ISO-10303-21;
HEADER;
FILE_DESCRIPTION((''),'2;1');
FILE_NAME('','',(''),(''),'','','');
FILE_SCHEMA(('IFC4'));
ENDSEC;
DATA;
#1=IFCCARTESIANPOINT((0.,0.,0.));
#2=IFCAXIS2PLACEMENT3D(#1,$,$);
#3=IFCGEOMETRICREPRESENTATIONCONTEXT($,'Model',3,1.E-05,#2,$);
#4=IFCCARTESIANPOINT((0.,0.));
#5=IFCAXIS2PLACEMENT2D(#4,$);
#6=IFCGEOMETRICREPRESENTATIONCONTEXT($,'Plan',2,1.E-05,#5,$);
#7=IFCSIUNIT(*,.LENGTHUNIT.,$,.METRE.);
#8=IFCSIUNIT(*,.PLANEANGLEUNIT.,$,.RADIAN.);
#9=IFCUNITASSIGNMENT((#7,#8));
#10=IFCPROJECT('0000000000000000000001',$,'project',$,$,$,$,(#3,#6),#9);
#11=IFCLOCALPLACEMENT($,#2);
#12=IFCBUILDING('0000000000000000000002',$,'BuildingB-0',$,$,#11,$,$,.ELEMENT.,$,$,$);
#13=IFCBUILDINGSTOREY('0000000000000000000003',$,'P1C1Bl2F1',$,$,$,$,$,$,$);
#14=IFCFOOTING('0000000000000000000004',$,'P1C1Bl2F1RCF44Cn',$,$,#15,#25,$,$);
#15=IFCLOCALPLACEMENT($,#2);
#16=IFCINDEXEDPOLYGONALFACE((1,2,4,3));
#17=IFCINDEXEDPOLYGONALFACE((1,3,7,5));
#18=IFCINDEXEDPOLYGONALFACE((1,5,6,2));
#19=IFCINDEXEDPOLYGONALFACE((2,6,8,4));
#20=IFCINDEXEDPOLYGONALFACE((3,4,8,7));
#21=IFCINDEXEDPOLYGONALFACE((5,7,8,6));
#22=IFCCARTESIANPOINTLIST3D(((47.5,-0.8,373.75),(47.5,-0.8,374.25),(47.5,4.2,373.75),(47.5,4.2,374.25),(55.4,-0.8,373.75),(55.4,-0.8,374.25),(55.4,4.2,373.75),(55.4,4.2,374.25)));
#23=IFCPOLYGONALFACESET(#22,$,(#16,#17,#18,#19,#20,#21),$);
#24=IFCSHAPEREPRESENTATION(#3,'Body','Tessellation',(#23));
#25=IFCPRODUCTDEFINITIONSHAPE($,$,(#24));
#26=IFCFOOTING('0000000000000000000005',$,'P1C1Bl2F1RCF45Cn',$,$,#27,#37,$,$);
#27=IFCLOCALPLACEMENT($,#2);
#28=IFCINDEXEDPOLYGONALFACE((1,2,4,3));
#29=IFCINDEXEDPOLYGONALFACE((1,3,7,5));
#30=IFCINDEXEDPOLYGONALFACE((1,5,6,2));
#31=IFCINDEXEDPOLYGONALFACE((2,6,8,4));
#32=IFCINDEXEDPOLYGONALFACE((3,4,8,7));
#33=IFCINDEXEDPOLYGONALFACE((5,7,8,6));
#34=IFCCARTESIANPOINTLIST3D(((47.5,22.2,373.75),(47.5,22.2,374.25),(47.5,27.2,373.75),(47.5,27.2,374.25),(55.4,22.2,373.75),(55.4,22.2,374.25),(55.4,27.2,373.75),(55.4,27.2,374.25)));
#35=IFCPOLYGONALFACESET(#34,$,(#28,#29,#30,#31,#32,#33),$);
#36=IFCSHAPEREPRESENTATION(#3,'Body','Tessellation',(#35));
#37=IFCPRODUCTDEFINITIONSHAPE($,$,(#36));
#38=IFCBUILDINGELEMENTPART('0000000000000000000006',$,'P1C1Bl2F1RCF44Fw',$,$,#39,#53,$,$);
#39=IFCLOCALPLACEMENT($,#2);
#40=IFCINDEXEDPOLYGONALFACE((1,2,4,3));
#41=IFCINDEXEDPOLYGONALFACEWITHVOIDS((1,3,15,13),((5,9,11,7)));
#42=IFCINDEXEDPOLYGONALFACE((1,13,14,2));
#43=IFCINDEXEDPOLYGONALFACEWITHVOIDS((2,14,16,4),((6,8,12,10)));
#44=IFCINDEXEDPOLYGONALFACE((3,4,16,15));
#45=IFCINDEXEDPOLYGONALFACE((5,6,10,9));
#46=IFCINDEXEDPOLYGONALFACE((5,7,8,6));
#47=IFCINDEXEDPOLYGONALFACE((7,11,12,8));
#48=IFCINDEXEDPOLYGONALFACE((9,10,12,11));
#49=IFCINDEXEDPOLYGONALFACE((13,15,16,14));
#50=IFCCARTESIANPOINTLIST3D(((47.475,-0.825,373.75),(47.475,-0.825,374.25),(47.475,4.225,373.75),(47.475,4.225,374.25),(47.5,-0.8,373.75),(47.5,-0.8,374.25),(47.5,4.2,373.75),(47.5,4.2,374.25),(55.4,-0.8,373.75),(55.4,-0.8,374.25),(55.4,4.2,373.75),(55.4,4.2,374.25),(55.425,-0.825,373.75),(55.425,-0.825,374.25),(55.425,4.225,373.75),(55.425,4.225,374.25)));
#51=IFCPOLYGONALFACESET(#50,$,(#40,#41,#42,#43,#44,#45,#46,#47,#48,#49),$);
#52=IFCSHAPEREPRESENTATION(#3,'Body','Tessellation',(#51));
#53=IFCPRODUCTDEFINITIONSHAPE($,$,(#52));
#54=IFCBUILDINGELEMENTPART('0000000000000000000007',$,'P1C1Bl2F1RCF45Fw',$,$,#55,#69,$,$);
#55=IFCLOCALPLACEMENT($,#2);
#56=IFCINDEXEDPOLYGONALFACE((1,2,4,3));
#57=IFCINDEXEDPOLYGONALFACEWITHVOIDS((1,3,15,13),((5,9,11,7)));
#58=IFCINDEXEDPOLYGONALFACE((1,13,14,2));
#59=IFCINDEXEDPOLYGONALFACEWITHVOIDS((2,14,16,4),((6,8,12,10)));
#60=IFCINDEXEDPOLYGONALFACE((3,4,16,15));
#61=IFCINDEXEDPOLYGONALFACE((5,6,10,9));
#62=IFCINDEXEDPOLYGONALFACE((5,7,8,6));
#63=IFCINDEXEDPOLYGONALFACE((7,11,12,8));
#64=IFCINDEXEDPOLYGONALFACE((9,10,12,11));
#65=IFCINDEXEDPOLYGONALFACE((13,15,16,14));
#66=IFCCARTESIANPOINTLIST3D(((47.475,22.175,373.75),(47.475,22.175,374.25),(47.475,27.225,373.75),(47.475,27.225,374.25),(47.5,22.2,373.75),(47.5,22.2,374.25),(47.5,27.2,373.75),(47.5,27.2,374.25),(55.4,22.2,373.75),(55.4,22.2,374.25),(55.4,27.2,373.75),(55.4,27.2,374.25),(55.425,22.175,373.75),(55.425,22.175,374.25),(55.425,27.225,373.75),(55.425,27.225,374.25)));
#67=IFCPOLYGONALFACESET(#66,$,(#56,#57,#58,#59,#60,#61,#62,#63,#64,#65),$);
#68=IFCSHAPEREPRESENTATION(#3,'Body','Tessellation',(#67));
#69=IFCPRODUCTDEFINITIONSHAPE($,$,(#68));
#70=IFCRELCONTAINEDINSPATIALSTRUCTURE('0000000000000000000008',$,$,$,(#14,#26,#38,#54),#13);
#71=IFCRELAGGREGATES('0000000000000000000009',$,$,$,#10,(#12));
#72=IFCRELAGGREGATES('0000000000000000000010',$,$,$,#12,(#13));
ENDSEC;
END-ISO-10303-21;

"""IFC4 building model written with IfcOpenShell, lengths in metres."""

from ifc_helpers import new_model, si_unit, origin, origin_2d, place, context, project, spatial, polyline, outline, extrude, element, save


model = new_model("IFC4")

# Units and contexts
model_context = context("Model", 3, precision=1e-05, world=origin())
plan_context = context("Plan", 2, precision=1e-05, world=origin_2d())
ifc_project = project(units=[si_unit("LENGTHUNIT", "METRE"), si_unit("PLANEANGLEUNIT", "RADIAN")], contexts=[model_context, plan_context])

# Building, storey
building_placement = place(None, origin())
building = spatial("IfcBuilding", under=ifc_project, at=building_placement, Name="BuildingB-0", CompositionType="ELEMENT")
storey = spatial("IfcBuildingStorey", under=building, Name="P1C1Bl2F1")

# Footings
element("IfcFooting", 1, inside=storey, Name="P1C1Bl2F1RCF44Cn", context=model_context, shape_type="SweptSolid", body=[
    extrude(outline(polyline([(55.4, 4.2, 373.75), (47.5, 4.2, 373.75), (47.5, -0.8, 373.75), (55.4, -0.8, 373.75), (55.4, 4.2, 373.75)])), None, (0.0, 0.0, 1.0), 0.5),
])
element("IfcFooting", 2, inside=storey, Name="P1C1Bl2F1RCF45Cn", context=model_context, shape_type="SweptSolid", body=[
    extrude(outline(polyline([(55.4, 27.2, 373.75), (47.5, 27.2, 373.75), (47.5, 22.2, 373.75), (55.4, 22.2, 373.75), (55.4, 27.2, 373.75)])), None, (0.0, 0.0, 1.0), 0.5),
])

# Building element part, opening
building_element_part_1 = element("IfcBuildingElementPart", 3, inside=storey, Name="P1C1Bl2F1RCF44Fw", context=model_context, shape_type="SweptSolid", body=[
    extrude(outline(polyline([(55.425, 4.225, 373.75), (47.475, 4.225, 373.75), (47.475, -0.825, 373.75), (55.425, -0.825, 373.75), (55.425, 4.225, 373.75)])), None, (0.0, 0.0, 1.0), 0.5),
])
element("IfcOpeningElement", 4, inside=storey, cuts=building_element_part_1, context=model_context, shape_type="SweptSolid", body=[
    extrude(outline(polyline([(55.4, 4.2, 373.75), (47.5, 4.2, 373.75), (47.5, -0.8, 373.75), (55.4, -0.8, 373.75), (55.4, 4.2, 373.75)])), None, (0.0, 0.0, 1.0), 0.5),
])

# Building element part, opening
building_element_part_2 = element("IfcBuildingElementPart", 5, inside=storey, Name="P1C1Bl2F1RCF45Fw", context=model_context, shape_type="SweptSolid", body=[
    extrude(outline(polyline([(55.425, 27.225, 373.75), (47.475, 27.225, 373.75), (47.475, 22.175, 373.75), (55.425, 22.175, 373.75), (55.425, 27.225, 373.75)])), None, (0.0, 0.0, 1.0), 0.5),
])
element("IfcOpeningElement", 6, inside=storey, cuts=building_element_part_2, context=model_context, shape_type="SweptSolid", body=[
    extrude(outline(polyline([(55.4, 27.2, 373.75), (47.5, 27.2, 373.75), (47.5, 22.2, 373.75), (55.4, 22.2, 373.75), (55.4, 27.2, 373.75)])), None, (0.0, 0.0, 1.0), 0.5),
])

save(model, "model.ifc")
